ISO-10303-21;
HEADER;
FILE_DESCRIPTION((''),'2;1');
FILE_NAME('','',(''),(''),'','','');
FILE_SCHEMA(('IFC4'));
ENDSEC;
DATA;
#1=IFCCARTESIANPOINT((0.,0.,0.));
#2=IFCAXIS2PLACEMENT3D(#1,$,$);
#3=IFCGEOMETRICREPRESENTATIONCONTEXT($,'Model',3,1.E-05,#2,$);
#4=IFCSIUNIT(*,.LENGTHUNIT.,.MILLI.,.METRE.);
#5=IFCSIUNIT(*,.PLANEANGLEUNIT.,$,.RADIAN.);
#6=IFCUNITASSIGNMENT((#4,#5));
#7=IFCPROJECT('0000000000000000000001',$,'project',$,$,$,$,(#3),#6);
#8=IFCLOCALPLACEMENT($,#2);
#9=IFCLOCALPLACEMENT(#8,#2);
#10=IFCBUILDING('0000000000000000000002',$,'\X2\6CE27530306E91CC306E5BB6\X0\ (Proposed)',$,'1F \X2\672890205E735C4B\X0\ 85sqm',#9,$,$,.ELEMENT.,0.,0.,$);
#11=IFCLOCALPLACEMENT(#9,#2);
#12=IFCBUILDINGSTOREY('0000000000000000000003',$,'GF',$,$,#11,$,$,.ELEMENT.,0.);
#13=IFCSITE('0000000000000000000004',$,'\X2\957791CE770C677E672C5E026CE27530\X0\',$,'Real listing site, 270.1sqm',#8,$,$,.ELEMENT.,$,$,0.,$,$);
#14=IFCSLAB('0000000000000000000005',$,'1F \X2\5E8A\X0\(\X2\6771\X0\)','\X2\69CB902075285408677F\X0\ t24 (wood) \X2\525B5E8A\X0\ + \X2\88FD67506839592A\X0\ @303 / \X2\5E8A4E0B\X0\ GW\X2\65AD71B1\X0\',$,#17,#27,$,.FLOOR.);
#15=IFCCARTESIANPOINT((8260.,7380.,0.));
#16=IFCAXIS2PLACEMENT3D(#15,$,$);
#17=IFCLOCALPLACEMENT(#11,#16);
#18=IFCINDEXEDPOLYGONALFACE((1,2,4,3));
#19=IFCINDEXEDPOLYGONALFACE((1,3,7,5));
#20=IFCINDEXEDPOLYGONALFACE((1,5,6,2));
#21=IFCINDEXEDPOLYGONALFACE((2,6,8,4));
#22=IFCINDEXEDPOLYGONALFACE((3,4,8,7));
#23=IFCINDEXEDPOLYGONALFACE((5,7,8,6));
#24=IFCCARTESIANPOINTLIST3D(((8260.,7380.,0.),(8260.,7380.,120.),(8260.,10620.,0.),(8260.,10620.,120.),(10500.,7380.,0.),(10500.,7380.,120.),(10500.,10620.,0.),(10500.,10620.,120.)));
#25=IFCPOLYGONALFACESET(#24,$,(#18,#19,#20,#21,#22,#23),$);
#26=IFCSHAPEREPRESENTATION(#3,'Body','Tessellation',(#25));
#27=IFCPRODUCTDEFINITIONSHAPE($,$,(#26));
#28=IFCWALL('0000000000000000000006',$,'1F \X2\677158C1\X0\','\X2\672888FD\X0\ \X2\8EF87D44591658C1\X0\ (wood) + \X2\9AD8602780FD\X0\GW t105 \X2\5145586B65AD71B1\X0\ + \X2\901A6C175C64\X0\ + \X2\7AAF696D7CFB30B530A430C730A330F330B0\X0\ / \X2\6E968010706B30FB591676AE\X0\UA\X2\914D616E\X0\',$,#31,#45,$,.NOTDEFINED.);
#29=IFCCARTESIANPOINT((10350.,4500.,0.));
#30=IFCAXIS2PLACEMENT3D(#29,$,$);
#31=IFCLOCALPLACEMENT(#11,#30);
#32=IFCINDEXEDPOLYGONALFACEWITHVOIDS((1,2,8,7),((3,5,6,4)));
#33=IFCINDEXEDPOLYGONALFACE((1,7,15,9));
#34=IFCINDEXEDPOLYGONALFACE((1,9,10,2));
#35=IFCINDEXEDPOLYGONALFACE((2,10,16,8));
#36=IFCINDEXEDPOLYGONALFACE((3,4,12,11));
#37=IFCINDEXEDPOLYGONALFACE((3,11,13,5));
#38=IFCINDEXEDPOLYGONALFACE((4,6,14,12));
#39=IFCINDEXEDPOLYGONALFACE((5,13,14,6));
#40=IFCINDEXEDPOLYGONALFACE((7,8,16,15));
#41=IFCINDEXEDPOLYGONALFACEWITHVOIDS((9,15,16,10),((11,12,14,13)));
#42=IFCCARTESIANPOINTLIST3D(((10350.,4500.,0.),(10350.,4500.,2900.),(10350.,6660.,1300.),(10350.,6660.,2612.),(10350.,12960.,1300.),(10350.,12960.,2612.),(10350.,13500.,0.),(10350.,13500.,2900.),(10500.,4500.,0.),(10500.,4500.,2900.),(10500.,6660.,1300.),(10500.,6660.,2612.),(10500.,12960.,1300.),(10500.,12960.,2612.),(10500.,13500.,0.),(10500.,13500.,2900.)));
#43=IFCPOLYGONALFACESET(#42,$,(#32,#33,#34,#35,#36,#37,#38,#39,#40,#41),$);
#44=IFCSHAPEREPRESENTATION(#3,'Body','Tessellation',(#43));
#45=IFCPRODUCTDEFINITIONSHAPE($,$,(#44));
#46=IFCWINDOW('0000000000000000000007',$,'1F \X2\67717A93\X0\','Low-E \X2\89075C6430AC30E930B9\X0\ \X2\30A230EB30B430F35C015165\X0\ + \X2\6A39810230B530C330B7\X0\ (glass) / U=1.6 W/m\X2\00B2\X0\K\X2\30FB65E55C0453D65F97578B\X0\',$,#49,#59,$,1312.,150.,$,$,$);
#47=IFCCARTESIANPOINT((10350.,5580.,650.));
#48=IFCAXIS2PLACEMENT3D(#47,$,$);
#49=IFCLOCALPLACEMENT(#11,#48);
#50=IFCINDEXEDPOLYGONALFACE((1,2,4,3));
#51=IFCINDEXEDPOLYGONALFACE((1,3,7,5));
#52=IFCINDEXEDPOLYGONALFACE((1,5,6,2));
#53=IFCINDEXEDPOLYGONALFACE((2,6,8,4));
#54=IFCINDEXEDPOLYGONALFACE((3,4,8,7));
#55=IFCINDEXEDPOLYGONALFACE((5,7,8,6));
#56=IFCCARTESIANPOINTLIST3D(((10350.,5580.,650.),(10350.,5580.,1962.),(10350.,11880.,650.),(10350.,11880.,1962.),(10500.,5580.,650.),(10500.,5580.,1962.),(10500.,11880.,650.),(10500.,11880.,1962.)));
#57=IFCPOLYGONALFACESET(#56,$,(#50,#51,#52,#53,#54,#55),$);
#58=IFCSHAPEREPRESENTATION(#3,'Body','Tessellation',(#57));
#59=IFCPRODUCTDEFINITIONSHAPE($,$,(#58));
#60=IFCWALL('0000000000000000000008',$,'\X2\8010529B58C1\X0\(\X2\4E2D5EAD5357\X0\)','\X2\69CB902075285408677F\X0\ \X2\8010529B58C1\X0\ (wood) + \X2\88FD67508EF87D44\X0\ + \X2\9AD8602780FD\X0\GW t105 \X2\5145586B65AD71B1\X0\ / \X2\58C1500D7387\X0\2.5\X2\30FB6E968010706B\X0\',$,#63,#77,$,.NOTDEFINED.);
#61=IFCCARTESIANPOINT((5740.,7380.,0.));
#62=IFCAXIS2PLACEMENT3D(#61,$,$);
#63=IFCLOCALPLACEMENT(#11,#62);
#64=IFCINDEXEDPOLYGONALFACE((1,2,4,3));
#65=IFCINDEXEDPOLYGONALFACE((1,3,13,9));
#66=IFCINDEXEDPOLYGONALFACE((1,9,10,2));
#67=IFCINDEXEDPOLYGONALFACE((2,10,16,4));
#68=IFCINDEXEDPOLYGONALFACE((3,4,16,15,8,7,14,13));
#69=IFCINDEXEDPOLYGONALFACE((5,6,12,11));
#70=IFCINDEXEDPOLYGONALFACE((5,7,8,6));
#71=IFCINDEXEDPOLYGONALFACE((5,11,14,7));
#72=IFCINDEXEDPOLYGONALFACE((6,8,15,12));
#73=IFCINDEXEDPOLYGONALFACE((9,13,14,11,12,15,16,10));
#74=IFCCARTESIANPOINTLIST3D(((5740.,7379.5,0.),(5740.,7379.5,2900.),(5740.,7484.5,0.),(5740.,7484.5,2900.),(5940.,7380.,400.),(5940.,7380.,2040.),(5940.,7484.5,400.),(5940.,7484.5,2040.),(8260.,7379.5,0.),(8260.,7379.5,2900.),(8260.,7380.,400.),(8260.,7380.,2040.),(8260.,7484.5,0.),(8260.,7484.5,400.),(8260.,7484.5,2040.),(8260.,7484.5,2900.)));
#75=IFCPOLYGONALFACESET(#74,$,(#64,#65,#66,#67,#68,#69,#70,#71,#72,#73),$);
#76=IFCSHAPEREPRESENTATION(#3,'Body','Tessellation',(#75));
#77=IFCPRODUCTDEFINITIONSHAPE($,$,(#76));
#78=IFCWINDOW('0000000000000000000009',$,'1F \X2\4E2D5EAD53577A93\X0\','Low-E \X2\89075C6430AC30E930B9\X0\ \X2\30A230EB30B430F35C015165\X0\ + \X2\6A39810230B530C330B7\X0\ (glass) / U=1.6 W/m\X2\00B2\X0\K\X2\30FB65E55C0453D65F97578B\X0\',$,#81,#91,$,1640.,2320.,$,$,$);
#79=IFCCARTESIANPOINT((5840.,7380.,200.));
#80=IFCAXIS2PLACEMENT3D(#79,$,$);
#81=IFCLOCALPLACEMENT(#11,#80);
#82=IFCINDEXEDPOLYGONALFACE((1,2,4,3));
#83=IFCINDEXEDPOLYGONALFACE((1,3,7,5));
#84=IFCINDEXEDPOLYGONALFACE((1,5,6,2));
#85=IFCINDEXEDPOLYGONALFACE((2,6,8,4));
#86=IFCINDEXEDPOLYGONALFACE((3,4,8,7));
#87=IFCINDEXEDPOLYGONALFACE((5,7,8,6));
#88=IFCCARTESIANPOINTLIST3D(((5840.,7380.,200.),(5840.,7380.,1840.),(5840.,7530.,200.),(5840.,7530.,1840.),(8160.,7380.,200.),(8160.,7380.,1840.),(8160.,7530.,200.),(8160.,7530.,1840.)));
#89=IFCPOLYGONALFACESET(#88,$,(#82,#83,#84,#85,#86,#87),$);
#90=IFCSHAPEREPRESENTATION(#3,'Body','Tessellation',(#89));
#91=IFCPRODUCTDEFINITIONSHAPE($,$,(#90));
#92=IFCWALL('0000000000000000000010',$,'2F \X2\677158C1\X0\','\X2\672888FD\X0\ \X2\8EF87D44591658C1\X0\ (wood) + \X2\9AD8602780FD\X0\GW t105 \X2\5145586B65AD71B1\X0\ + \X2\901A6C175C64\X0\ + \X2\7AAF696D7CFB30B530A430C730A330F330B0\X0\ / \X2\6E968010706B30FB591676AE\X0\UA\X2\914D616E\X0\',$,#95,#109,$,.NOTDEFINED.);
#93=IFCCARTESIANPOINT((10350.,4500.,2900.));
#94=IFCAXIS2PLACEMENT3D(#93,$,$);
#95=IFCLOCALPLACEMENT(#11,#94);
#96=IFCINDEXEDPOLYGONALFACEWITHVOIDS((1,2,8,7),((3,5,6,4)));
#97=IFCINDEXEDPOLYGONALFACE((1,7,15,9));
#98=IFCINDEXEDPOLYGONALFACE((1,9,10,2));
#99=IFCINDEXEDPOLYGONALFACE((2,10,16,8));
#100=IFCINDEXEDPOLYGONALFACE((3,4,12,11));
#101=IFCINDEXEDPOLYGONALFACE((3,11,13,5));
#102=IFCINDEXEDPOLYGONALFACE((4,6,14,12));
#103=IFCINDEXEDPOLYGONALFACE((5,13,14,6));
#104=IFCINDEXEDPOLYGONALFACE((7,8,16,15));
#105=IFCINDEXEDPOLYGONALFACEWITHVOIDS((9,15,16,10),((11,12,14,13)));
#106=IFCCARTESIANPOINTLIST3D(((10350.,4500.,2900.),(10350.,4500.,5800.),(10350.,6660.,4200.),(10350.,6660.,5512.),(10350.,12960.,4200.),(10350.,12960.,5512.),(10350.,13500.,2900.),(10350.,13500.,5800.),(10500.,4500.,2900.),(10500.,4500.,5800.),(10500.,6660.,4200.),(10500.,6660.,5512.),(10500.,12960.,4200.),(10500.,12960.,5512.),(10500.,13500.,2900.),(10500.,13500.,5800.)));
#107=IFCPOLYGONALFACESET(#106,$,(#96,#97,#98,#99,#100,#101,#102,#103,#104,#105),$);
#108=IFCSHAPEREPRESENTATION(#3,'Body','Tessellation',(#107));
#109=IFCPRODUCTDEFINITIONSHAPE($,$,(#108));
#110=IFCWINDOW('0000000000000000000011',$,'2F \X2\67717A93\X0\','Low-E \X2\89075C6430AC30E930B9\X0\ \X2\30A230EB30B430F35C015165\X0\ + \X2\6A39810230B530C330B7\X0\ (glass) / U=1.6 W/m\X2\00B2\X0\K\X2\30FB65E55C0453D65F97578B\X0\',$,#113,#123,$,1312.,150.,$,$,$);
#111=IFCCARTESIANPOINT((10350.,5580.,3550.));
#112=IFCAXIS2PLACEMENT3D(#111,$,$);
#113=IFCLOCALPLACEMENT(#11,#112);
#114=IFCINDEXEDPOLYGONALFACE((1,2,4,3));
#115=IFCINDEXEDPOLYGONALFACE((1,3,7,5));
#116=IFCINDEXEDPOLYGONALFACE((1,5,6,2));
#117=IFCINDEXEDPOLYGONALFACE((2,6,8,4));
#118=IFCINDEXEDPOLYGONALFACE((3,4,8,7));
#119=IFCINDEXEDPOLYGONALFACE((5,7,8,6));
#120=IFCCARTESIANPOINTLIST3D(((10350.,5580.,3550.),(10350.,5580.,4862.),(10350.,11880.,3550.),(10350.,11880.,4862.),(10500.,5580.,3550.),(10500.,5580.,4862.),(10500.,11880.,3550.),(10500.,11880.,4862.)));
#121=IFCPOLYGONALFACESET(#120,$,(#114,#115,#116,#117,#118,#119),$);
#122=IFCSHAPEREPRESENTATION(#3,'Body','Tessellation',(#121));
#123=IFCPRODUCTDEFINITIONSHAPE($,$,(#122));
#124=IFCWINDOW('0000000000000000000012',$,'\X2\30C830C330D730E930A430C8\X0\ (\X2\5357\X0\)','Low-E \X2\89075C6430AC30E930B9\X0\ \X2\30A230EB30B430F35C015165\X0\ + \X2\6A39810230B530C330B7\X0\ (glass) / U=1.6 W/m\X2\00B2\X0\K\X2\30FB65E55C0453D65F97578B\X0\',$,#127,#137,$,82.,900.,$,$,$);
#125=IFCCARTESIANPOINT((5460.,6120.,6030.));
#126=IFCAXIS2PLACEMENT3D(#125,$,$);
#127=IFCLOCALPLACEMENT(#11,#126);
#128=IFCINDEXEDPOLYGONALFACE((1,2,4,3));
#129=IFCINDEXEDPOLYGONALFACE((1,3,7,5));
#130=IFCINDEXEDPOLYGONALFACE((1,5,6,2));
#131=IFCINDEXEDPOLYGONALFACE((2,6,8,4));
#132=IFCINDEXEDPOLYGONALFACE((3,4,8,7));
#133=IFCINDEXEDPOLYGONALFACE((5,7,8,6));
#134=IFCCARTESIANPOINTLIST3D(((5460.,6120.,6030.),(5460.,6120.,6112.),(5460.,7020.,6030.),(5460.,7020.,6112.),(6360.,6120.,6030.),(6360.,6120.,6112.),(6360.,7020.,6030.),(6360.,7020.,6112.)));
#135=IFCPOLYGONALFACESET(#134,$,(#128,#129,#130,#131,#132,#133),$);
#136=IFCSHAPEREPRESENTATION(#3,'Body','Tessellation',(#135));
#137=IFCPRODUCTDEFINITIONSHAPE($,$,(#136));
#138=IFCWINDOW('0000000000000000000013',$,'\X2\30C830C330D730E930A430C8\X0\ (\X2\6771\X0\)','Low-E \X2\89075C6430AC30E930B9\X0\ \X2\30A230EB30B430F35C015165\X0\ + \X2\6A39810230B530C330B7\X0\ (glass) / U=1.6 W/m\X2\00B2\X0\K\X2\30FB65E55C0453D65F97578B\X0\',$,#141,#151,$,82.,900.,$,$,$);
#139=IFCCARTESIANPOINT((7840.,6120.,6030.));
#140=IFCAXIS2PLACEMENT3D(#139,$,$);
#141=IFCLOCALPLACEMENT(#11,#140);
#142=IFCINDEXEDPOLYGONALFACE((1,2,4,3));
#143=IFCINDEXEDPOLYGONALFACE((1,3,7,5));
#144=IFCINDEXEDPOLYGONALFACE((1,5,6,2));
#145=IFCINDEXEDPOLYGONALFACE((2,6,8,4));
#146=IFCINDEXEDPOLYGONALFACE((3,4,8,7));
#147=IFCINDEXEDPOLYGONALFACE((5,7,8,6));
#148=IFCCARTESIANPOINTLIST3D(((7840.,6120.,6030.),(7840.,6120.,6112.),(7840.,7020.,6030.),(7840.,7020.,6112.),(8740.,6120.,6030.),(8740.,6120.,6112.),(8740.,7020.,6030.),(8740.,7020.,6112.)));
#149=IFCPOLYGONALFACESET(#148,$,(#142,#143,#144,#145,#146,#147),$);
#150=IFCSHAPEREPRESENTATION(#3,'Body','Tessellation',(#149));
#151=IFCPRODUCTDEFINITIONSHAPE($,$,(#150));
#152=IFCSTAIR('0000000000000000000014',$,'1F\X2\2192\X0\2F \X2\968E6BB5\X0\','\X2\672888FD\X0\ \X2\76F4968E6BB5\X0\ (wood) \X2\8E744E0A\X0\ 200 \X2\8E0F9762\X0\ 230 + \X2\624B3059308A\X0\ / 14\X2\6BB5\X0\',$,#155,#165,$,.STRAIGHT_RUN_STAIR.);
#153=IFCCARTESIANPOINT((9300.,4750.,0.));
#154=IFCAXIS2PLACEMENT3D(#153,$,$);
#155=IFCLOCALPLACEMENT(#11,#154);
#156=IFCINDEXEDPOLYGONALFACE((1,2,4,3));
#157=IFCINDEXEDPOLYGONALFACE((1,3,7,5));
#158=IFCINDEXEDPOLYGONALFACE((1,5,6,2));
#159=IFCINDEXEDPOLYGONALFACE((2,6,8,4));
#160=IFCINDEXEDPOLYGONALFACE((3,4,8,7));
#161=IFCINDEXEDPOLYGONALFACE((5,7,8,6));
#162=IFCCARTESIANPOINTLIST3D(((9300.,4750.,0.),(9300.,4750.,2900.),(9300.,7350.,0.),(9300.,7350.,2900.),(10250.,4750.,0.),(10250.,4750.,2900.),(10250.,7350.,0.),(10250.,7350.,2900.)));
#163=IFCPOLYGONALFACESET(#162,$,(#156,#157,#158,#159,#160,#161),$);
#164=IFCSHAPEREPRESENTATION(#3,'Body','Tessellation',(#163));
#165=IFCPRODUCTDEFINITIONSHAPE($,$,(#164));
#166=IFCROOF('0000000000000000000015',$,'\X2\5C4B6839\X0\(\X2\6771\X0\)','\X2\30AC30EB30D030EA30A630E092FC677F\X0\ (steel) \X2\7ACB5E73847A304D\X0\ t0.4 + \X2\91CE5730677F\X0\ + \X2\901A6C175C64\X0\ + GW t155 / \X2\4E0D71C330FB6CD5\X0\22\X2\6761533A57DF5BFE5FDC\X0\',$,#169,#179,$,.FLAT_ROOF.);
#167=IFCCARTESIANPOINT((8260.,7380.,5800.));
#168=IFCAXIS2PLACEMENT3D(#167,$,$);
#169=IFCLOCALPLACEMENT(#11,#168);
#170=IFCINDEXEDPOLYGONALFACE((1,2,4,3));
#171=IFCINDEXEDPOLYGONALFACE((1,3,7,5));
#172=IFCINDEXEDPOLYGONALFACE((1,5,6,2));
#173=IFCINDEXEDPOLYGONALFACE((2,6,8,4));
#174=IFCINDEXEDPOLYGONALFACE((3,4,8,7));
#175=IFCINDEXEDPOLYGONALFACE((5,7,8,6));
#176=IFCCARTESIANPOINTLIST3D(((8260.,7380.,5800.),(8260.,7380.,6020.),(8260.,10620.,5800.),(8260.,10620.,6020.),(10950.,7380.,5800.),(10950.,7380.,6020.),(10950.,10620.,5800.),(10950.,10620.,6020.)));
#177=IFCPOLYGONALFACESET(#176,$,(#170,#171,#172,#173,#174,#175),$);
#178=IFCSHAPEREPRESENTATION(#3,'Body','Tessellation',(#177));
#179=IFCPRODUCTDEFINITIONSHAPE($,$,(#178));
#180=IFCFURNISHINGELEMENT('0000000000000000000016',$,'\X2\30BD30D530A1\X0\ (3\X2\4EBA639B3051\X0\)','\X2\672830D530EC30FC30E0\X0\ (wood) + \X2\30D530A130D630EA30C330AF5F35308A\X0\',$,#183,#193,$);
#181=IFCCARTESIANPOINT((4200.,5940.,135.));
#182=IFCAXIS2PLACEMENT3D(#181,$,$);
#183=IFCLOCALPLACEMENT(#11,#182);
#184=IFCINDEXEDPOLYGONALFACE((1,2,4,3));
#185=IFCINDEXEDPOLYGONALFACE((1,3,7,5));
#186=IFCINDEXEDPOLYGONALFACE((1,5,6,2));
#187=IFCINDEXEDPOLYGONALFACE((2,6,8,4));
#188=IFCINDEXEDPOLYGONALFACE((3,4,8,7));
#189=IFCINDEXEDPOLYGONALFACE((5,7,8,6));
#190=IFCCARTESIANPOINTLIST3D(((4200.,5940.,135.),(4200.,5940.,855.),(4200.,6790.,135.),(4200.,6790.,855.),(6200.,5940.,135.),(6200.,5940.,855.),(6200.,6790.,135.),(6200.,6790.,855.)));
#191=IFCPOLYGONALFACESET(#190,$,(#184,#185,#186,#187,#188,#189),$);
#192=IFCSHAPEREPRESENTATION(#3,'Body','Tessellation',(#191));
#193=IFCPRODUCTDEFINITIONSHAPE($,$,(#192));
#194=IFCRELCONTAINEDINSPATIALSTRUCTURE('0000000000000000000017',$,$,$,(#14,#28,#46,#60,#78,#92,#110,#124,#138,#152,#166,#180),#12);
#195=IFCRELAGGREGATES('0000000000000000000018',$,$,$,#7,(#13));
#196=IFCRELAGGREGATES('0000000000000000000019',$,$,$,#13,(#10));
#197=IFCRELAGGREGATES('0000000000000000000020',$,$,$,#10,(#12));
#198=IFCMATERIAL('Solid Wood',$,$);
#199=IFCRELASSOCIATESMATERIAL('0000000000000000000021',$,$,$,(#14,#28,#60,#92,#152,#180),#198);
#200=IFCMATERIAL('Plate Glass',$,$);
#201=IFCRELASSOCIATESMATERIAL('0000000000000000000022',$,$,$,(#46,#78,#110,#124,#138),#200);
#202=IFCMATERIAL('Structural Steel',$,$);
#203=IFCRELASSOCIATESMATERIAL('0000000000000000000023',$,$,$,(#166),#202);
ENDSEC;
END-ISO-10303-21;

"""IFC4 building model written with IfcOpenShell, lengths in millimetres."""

from ifc_helpers import new_model, si_unit, frame, frame_2d, origin, place, context, project, spatial, rectangle, extrude, material, element, fill, save


model = new_model("IFC4")

# Units and contexts
model_context = context("Model", 3, precision=1e-05, world=origin())
ifc_project = project(units=[si_unit("LENGTHUNIT", "METRE", prefix="MILLI"), si_unit("PLANEANGLEUNIT", "RADIAN")], contexts=[model_context])

# Site, building, storey
site_placement = place(None, origin())
site = spatial("IfcSite", under=ifc_project, at=site_placement, Name="長野県松本市波田", ObjectType="Real listing site, 270.1sqm", CompositionType="ELEMENT", RefElevation=0.0)
building_placement = place(site_placement, origin())
building = spatial("IfcBuilding", under=site, at=building_placement, Name="波田の里の家 (Proposed)", ObjectType="1F 木造平屋 85sqm", CompositionType="ELEMENT", ElevationOfRefHeight=0.0, ElevationOfTerrain=0.0)
storey_placement = place(building_placement, origin())
storey = spatial("IfcBuildingStorey", under=building, at=storey_placement, Name="GF", CompositionType="ELEMENT", Elevation=0.0)

# Slab
ifc_material_1 = material(Name="Solid Wood")
slab_placement = place(storey_placement, frame((8260.0, 7380.0, 0.0)))
element("IfcSlab", 1, at=slab_placement, inside=storey, material=ifc_material_1, Name="1F 床(東)", Description="構造用合板 t24 (wood) 剛床 + 製材根太 @303 / 床下 GW断熱", PredefinedType="FLOOR", context=model_context, shape_type="SweptSolid", body=[
    extrude(rectangle(XDim=2240.0, YDim=3240.0, at=frame_2d((1120.0, 1620.0))), frame((8260.0, 7380.0, 0.0)), (0.0, 0.0, 1.0), 120.0),
])

# Walls, openings, windows
wall_1_placement = place(storey_placement, frame((10350.0, 4500.0, 0.0)))
wall_1 = element("IfcWall", 2, at=wall_1_placement, inside=storey, material=ifc_material_1, Name="1F 東壁", Description="木製 軸組外壁 (wood) + 高性能GW t105 充填断熱 + 通気層 + 窯業系サイディング / 準耐火・外皮UA配慮", PredefinedType="NOTDEFINED", context=model_context, shape_type="SweptSolid", body=[
    extrude(rectangle(XDim=150.0, YDim=9000.0, at=frame_2d((75.0, 4500.0))), frame((10350.0, 4500.0, 0.0)), (0.0, 0.0, 1.0), 2900.0),
])
opening_1_placement = place(storey_placement, frame((10350.0, 5580.0, 650.0)))
opening_1 = element("IfcOpeningElement", 3, at=opening_1_placement, cuts=wall_1, PredefinedType="NOTDEFINED", context=model_context, shape_type="SweptSolid", body=[
    extrude(rectangle(XDim=150.0, YDim=6300.0, at=frame_2d((75.0, 3150.0))), frame((10350.0, 5580.0, 650.0)), (0.0, 0.0, 1.0), 1312.0),
])
ifc_material_2 = material(Name="Plate Glass")
window_1_placement = place(storey_placement, frame((10350.0, 5580.0, 650.0)))
window_1 = element("IfcWindow", 4, at=window_1_placement, inside=storey, material=ifc_material_2, Name="1F 東窓", Description="Low-E 複層ガラス アルゴン封入 + 樹脂サッシ (glass) / U=1.6 W/m²K・日射取得型", OverallHeight=1312.0, OverallWidth=150.0, context=model_context, shape_type="SweptSolid", body=[
    extrude(rectangle(XDim=150.0, YDim=6300.0, at=frame_2d((75.0, 3150.0))), frame((10350.0, 5580.0, 650.0)), (0.0, 0.0, 1.0), 1312.0),
])
fill(opening_1, window_1)
wall_2_placement = place(storey_placement, frame((5740.0, 7380.0, 0.0)))
wall_2 = element("IfcWall", 5, at=wall_2_placement, inside=storey, material=ifc_material_1, Name="耐力壁(中庭南)", Description="構造用合板 耐力壁 (wood) + 製材軸組 + 高性能GW t105 充填断熱 / 壁倍率2.5・準耐火", PredefinedType="NOTDEFINED", context=model_context, shape_type="SweptSolid", body=[
    extrude(rectangle(XDim=2520.0, YDim=105.0, at=frame_2d((1260.0, 52.0))), frame((5740.0, 7380.0, 0.0)), (0.0, 0.0, 1.0), 2900.0),
])
opening_2_placement = place(storey_placement, frame((5840.0, 7380.0, 200.0)))
opening_2 = element("IfcOpeningElement", 6, at=opening_2_placement, cuts=wall_2, PredefinedType="NOTDEFINED", context=model_context, shape_type="SweptSolid", body=[
    extrude(rectangle(XDim=2320.0, YDim=150.0, at=frame_2d((1160.0, 75.0))), frame((5840.0, 7380.0, 200.0)), (0.0, 0.0, 1.0), 1640.0),
])
window_2_placement = place(storey_placement, frame((5840.0, 7380.0, 200.0)))
window_2 = element("IfcWindow", 7, at=window_2_placement, inside=storey, material=ifc_material_2, Name="1F 中庭南窓", Description="Low-E 複層ガラス アルゴン封入 + 樹脂サッシ (glass) / U=1.6 W/m²K・日射取得型", OverallHeight=1640.0, OverallWidth=2320.0, context=model_context, shape_type="SweptSolid", body=[
    extrude(rectangle(XDim=2320.0, YDim=150.0, at=frame_2d((1160.0, 75.0))), frame((5840.0, 7380.0, 200.0)), (0.0, 0.0, 1.0), 1640.0),
])
fill(opening_2, window_2)

# Wall, opening, window
wall_3_placement = place(storey_placement, frame((10350.0, 4500.0, 2900.0)))
wall_3 = element("IfcWall", 8, at=wall_3_placement, inside=storey, material=ifc_material_1, Name="2F 東壁", Description="木製 軸組外壁 (wood) + 高性能GW t105 充填断熱 + 通気層 + 窯業系サイディング / 準耐火・外皮UA配慮", PredefinedType="NOTDEFINED", context=model_context, shape_type="SweptSolid", body=[
    extrude(rectangle(XDim=150.0, YDim=9000.0, at=frame_2d((75.0, 4500.0))), frame((10350.0, 4500.0, 2900.0)), (0.0, 0.0, 1.0), 2900.0),
])
opening_3_placement = place(storey_placement, frame((10350.0, 5580.0, 3550.0)))
opening_3 = element("IfcOpeningElement", 9, at=opening_3_placement, cuts=wall_3, PredefinedType="NOTDEFINED", context=model_context, shape_type="SweptSolid", body=[
    extrude(rectangle(XDim=150.0, YDim=6300.0, at=frame_2d((75.0, 3150.0))), frame((10350.0, 5580.0, 3550.0)), (0.0, 0.0, 1.0), 1312.0),
])
window_3_placement = place(storey_placement, frame((10350.0, 5580.0, 3550.0)))
window_3 = element("IfcWindow", 10, at=window_3_placement, inside=storey, material=ifc_material_2, Name="2F 東窓", Description="Low-E 複層ガラス アルゴン封入 + 樹脂サッシ (glass) / U=1.6 W/m²K・日射取得型", OverallHeight=1312.0, OverallWidth=150.0, context=model_context, shape_type="SweptSolid", body=[
    extrude(rectangle(XDim=150.0, YDim=6300.0, at=frame_2d((75.0, 3150.0))), frame((10350.0, 5580.0, 3550.0)), (0.0, 0.0, 1.0), 1312.0),
])
fill(opening_3, window_3)

# Windows
window_4_placement = place(storey_placement, frame((5460.0, 6120.0, 6030.0)))
element("IfcWindow", 11, at=window_4_placement, inside=storey, material=ifc_material_2, Name="トップライト (南)", Description="Low-E 複層ガラス アルゴン封入 + 樹脂サッシ (glass) / U=1.6 W/m²K・日射取得型", OverallHeight=82.0, OverallWidth=900.0, context=model_context, shape_type="SweptSolid", body=[
    extrude(rectangle(XDim=900.0, YDim=900.0, at=frame_2d((450.0, 450.0))), frame((5460.0, 6120.0, 6030.0)), (0.0, 0.0, 1.0), 82.0),
])
window_5_placement = place(storey_placement, frame((7840.0, 6120.0, 6030.0)))
element("IfcWindow", 12, at=window_5_placement, inside=storey, material=ifc_material_2, Name="トップライト (東)", Description="Low-E 複層ガラス アルゴン封入 + 樹脂サッシ (glass) / U=1.6 W/m²K・日射取得型", OverallHeight=82.0, OverallWidth=900.0, context=model_context, shape_type="SweptSolid", body=[
    extrude(rectangle(XDim=900.0, YDim=900.0, at=frame_2d((450.0, 450.0))), frame((7840.0, 6120.0, 6030.0)), (0.0, 0.0, 1.0), 82.0),
])

# Stair
stair_placement = place(storey_placement, frame((9300.0, 4750.0, 0.0)))
element("IfcStair", 13, at=stair_placement, inside=storey, material=ifc_material_1, Name="1F→2F 階段", Description="木製 直階段 (wood) 蹴上 200 踏面 230 + 手すり / 14段", PredefinedType="STRAIGHT_RUN_STAIR", context=model_context, shape_type="SweptSolid", body=[
    extrude(rectangle(XDim=950.0, YDim=2600.0, at=frame_2d((475.0, 1300.0))), frame((9300.0, 4750.0, 0.0)), (0.0, 0.0, 1.0), 2900.0),
])

# Roof
ifc_material_3 = material(Name="Structural Steel")
roof_placement = place(storey_placement, frame((8260.0, 7380.0, 5800.0)))
element("IfcRoof", 14, at=roof_placement, inside=storey, material=ifc_material_3, Name="屋根(東)", Description="ガルバリウム鋼板 (steel) 立平葺き t0.4 + 野地板 + 通気層 + GW t155 / 不燃・法22条区域対応", PredefinedType="FLAT_ROOF", context=model_context, shape_type="SweptSolid", body=[
    extrude(rectangle(XDim=2690.0, YDim=3240.0, at=frame_2d((1345.0, 1620.0))), frame((8260.0, 7380.0, 5800.0)), (0.0, 0.0, 1.0), 220.0),
])

# Furnishing element
furnishing_1_placement = place(storey_placement, frame((4200.0, 5940.0, 135.0)))
element("IfcFurnishingElement", 15, at=furnishing_1_placement, inside=storey, material=ifc_material_1, Name="ソファ (3人掛け)", Description="木フレーム (wood) + ファブリック張り", context=model_context, shape_type="SweptSolid", body=[
    extrude(rectangle(XDim=2000.0, YDim=850.0, at=frame_2d((1000.0, 425.0))), frame((4200.0, 5940.0, 135.0)), (0.0, 0.0, 1.0), 720.0),
])

save(model, "model.ifc")
